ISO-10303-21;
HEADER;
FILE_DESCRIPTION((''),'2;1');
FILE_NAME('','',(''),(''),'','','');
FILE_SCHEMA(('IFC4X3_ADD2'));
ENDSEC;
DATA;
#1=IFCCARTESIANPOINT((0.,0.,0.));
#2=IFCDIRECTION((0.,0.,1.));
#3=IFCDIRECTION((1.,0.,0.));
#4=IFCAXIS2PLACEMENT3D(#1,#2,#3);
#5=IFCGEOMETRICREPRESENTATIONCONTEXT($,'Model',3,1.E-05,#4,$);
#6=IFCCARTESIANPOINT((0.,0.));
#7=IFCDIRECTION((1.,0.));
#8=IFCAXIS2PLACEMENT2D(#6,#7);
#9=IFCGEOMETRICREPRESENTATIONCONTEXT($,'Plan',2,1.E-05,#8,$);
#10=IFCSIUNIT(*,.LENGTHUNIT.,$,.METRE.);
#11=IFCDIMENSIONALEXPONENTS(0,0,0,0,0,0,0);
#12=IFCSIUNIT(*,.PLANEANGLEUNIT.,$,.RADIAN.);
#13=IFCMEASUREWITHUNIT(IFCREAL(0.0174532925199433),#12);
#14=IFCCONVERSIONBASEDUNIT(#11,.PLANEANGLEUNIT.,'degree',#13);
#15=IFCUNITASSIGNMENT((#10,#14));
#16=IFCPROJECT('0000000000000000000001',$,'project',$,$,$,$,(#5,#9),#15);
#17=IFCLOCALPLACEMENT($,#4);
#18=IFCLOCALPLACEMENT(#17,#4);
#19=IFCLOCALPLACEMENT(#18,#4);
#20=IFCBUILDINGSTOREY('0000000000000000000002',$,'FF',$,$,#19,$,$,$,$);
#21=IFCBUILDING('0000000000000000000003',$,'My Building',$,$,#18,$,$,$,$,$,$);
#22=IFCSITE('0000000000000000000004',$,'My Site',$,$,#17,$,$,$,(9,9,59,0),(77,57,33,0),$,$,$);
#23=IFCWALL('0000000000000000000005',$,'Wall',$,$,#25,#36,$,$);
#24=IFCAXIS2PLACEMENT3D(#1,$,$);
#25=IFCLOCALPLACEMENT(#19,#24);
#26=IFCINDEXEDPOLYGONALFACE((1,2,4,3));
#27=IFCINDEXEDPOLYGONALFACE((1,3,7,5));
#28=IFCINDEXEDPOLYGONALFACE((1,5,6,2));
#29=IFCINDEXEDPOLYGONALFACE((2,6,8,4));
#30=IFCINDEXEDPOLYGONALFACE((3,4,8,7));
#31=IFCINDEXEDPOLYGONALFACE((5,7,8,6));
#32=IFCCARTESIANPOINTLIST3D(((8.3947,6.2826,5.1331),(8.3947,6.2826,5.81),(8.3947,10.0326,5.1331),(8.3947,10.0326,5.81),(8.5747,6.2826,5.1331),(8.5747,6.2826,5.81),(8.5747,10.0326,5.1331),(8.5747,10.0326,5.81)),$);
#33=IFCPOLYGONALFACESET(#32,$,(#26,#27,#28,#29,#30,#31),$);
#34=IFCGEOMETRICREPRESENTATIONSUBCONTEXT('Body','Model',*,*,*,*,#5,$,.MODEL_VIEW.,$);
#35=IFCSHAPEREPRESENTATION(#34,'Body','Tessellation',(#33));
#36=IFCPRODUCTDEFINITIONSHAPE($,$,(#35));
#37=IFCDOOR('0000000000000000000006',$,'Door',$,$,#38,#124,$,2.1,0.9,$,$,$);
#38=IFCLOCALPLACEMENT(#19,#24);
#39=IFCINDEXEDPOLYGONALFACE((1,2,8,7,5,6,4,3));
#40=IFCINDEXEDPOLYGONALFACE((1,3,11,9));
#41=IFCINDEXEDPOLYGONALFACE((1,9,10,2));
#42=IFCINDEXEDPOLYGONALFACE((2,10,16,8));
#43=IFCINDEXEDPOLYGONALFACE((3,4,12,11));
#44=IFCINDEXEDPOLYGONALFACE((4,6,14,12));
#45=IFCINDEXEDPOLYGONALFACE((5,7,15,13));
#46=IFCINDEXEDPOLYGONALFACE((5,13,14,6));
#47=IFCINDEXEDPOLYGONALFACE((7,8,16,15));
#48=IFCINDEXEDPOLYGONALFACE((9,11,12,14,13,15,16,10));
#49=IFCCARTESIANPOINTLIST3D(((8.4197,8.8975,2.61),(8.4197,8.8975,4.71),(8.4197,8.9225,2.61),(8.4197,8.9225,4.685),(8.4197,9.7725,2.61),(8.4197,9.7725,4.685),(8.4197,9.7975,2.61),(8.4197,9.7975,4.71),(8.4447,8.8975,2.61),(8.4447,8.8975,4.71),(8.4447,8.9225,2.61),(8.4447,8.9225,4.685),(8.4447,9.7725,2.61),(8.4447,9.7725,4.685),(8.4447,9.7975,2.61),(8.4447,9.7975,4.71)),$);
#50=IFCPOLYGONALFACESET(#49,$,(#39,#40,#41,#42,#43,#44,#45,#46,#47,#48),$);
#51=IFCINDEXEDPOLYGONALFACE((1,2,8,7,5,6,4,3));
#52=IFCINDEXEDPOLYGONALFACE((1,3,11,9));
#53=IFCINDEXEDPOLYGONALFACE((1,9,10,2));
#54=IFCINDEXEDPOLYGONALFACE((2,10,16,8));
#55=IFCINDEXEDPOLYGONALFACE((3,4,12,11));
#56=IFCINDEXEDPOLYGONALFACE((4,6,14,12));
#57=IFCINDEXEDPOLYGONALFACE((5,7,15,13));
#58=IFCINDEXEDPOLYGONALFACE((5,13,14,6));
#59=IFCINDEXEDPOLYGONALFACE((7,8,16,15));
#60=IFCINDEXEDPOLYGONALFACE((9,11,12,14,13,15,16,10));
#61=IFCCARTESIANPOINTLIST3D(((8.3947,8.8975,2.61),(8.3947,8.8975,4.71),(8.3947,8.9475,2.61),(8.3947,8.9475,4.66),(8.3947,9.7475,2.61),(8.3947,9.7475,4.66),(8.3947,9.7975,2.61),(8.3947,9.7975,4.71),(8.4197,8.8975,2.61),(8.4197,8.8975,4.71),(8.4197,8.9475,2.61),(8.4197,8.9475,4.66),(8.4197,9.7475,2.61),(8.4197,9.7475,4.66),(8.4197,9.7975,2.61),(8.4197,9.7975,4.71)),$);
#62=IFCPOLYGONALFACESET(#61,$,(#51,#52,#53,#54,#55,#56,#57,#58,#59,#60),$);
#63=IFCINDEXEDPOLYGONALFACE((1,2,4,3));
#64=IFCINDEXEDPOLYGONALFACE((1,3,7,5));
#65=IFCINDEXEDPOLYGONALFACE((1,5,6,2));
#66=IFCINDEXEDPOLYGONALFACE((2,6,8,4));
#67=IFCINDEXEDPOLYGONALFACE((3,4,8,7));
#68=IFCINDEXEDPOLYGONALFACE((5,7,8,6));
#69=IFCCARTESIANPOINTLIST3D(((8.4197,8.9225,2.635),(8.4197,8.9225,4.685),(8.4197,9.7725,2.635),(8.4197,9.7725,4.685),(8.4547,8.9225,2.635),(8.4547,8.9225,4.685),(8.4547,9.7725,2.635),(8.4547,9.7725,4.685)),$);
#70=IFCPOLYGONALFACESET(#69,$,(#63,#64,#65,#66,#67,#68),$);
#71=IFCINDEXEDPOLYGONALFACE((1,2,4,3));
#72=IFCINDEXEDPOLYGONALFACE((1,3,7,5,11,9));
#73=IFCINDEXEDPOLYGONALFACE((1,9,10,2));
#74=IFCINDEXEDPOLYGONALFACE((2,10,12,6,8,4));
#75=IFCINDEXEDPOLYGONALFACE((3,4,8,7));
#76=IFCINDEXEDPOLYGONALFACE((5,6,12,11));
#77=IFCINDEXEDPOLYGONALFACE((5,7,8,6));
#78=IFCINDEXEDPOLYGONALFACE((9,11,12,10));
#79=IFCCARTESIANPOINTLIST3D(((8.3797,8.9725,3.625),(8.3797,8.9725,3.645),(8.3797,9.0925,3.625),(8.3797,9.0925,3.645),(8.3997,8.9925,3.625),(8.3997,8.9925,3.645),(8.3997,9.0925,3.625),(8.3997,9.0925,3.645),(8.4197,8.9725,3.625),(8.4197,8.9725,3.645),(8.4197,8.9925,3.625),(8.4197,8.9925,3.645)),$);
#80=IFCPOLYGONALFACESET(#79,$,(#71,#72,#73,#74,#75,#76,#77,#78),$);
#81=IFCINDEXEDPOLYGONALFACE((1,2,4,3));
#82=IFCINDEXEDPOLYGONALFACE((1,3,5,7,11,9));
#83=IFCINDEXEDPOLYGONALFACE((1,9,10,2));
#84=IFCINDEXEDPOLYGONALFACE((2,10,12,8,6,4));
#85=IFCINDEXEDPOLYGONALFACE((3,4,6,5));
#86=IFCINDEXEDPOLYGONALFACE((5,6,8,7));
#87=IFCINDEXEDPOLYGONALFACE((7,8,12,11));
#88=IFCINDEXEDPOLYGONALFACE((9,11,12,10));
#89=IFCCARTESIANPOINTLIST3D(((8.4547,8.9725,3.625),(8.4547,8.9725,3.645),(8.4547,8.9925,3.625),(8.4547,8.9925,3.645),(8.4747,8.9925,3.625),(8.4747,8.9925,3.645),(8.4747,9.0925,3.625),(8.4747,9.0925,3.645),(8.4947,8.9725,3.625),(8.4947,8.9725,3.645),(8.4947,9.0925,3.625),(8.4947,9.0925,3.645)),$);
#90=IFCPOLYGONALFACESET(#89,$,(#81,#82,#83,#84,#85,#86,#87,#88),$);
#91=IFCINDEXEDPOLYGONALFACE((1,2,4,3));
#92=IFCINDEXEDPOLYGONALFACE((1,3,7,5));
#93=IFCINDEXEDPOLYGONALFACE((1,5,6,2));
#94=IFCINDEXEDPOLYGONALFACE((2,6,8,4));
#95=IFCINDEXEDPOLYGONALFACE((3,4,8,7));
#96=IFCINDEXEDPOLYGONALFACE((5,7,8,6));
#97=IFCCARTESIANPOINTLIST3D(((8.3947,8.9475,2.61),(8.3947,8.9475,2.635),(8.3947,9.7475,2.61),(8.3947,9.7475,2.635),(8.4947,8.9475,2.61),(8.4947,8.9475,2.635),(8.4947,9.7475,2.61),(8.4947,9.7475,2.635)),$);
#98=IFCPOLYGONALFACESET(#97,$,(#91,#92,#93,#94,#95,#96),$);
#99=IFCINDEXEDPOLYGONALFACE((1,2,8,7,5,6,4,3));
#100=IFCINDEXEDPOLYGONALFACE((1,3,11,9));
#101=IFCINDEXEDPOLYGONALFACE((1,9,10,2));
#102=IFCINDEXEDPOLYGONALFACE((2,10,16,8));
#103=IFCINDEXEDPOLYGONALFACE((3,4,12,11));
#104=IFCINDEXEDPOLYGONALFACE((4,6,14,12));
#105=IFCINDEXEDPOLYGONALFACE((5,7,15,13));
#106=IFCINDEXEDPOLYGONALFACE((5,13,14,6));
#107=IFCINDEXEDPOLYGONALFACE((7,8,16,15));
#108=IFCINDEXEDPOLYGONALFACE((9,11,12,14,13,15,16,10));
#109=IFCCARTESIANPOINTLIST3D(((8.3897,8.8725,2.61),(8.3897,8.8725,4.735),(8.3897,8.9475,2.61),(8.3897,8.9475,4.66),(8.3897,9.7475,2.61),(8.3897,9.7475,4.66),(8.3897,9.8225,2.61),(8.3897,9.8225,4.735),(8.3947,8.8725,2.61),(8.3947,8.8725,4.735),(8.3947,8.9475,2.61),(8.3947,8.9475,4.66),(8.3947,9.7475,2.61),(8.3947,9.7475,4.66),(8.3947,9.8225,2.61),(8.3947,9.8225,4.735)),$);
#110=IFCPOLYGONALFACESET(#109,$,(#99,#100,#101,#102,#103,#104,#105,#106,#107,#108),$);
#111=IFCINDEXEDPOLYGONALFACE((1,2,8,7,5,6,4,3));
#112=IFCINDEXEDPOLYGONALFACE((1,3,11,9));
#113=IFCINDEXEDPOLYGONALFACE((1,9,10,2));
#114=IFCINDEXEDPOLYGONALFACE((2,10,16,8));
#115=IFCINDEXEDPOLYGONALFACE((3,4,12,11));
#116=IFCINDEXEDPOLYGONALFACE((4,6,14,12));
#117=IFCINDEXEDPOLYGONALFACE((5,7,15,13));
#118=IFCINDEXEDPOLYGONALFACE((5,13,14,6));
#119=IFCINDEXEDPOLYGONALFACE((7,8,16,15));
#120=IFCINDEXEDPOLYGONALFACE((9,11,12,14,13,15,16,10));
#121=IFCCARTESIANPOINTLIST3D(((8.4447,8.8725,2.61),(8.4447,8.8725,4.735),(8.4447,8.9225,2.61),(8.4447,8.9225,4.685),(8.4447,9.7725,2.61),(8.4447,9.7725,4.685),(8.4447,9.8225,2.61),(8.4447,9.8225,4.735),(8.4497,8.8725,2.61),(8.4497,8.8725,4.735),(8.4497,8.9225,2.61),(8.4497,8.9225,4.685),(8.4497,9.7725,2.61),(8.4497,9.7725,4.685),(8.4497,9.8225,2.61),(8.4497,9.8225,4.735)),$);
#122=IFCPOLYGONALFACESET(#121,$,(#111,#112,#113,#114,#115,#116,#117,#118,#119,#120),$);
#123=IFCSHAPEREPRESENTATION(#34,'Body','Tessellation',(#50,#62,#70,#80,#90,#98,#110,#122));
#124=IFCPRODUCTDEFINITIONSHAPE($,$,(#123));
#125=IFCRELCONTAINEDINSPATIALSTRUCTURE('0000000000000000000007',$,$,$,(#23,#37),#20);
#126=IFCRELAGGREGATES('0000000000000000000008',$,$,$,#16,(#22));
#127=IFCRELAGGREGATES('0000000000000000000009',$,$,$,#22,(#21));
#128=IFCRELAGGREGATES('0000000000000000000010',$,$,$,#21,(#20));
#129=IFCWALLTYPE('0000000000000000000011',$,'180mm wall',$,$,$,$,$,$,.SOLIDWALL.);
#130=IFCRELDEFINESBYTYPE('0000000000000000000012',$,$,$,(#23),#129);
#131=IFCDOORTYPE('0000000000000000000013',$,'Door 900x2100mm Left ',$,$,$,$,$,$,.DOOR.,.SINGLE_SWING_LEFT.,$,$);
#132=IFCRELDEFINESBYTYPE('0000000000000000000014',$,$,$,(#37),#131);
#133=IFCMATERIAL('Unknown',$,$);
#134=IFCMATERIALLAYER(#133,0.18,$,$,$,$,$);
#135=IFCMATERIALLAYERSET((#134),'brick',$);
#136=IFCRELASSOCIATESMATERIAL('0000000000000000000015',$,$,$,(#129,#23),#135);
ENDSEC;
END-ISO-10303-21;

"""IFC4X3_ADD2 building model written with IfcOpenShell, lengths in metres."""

from ifc_helpers import new_model, entity, si_unit, converted_unit, frame, origin_with_axes, origin_2d_with_axis, place, context, subcontext, project, spatial, line, indexed_curve, outline, extrude, shape, source, transform, mapped, material, layer, layer_set, layer_usage, type_object, type_shapes, element, save


model = new_model("IFC4X3_ADD2")

# Units and contexts
model_context = context("Model", 3, precision=1e-05, world=origin_with_axes())
plan_context = context("Plan", 2, precision=1e-05, world=origin_2d_with_axis())
body_context_1 = subcontext(model_context, "Body", "Model", "MODEL_VIEW")
body_context_2 = subcontext(plan_context, "Body", "Plan", "PLAN_VIEW")
ifc_project = project(units=[si_unit("LENGTHUNIT", "METRE"), converted_unit("PLANEANGLEUNIT", "degree", entity("IfcReal", 0.0174532925199433), si_unit("PLANEANGLEUNIT", "RADIAN"), dimensions=[0, 0, 0, 0, 0, 0, 0])], contexts=[model_context, plan_context])

# Site, building, storey
site_placement = place(None, origin_with_axes())
site = spatial("IfcSite", under=ifc_project, at=site_placement, Name="My Site", RefLatitude=(9, 9, 59, 0), RefLongitude=(77, 57, 33, 0))
building_placement = place(site_placement, origin_with_axes())
building = spatial("IfcBuilding", under=site, at=building_placement, Name="My Building")
storey_placement = place(building_placement, origin_with_axes())
storey = spatial("IfcBuildingStorey", under=building, at=storey_placement, Name="FF")

# Shared definitions
ifc_material = material(Name="Unknown")

# Shared definitions
ifc_layer_1 = layer(ifc_material, 0.18)
ifc_layer_set_1 = layer_set([ifc_layer_1], Name="brick")
wall_type_1 = type_object("IfcWallType", Name="180mm wall", PredefinedType="SOLIDWALL", material=ifc_layer_set_1)

# Shared definitions
wall_1_placement = place(storey_placement, frame((8.5747, 8.3164, 2.61), z_axis=(0.0, 0.0, 1.0), x_axis=(0.0, 1.0, 0.0)))

# Wall
ifc_layer_usage_1 = layer_usage(ifc_layer_set_1, "AXIS2", "POSITIVE", 0.0)
wall_2_placement = place(storey_placement, frame((8.3947, 10.0326, 5.1331), z_axis=(0.0, 0.0, 1.0), x_axis=(-0.000001, -1.0, 0.0)))
element("IfcWall", 1, at=wall_2_placement, inside=storey, type_object=wall_type_1, material=ifc_layer_usage_1, Name="Wall", context=body_context_1, shape_type="SweptSolid", body=[
    extrude(outline(indexed_curve([(0.0, 0.0), (0.0, 0.18), (3.75, 0.18), (3.75, 0.0)], segments=[line(1, 2, 3, 4, 1)])), origin_with_axes(), (0.0, 0.0, 1.0), 0.6769),
])

# Door
door_type_1 = type_object("IfcDoorType", Name="Door 900x2100mm Left ", OperationType="SINGLE_SWING_LEFT", PredefinedType="DOOR")
shared_shape_1 = source(origin_with_axes(), body_context_1, "Body", "SweptSolid", [
    extrude(outline(indexed_curve([(0.0, 0.0), (0.0, 2.1), (0.9, 2.1), (0.9, 0.0), (0.875, 0.0), (0.875, 2.075), (0.025, 2.075), (0.025, 0.0)], segments=[line(1, 2, 3, 4, 5, 6, 7, 8, 1)])), frame((0.0, 0.025, 0.0), z_axis=(0.0, -1.0, 0.0), x_axis=(1.0, 0.0, 0.0)), (0.0, 0.0, -1.0), 0.025),
    extrude(outline(indexed_curve([(0.0, 0.0), (0.0, 2.1), (0.9, 2.1), (0.9, 0.0), (0.85, 0.0), (0.85, 2.05), (0.05, 2.05), (0.05, 0.0)], segments=[line(1, 2, 3, 4, 5, 6, 7, 8, 1)])), frame((0.0, 0.0, 0.0), z_axis=(0.0, -1.0, 0.0), x_axis=(1.0, 0.0, 0.0)), (0.0, 0.0, -1.0), 0.025),
    extrude(outline(indexed_curve([(0.0, 0.0), (0.85, 0.0), (0.85, 0.035), (0.0, 0.035)], segments=[line(1, 2, 3, 4, 1)])), frame((0.025, 0.025, 0.025), z_axis=(0.0, 0.0, 1.0), x_axis=(1.0, 0.0, 0.0)), (0.0, 0.0, 1.0), 2.05),
    extrude(outline(indexed_curve([(0.0, 0.0), (0.0, -0.04), (-0.12, -0.04), (-0.12, -0.02), (-0.02, -0.02), (-0.02, 0.0)], segments=[line(1, 2, 3, 4, 5, 6, 1)])), frame((0.825, 0.025, 1.015), z_axis=(0.0, 0.0, 1.0), x_axis=(1.0, 0.0, 0.0)), (0.0, 0.0, 1.0), 0.02),
    extrude(outline(indexed_curve([(0.0, 0.0), (0.0, 0.04), (-0.12, 0.04), (-0.12, 0.02), (-0.02, 0.02), (-0.02, 0.0)], segments=[line(1, 2, 3, 4, 5, 6, 1)])), frame((0.825, 0.06, 1.015), z_axis=(0.0, 0.0, 1.0), x_axis=(1.0, 0.0, 0.0)), (0.0, 0.0, 1.0), 0.02),
    extrude(outline(indexed_curve([(0.0, 0.0), (0.8, 0.0), (0.8, 0.1), (0.0, 0.1)], segments=[line(1, 2, 3, 4, 1)])), frame((0.05, 0.0, 0.0), z_axis=(0.0, 0.0, 1.0), x_axis=(1.0, 0.0, 0.0)), (0.0, 0.0, 1.0), 0.025),
    extrude(outline(indexed_curve([(0.0, 0.0), (0.0, 2.125), (0.95, 2.125), (0.95, 0.0), (0.875, 0.0), (0.875, 2.05), (0.075, 2.05), (0.075, 0.0)], segments=[line(1, 2, 3, 4, 5, 6, 7, 8, 1)])), frame((-0.025, -0.005, 0.0), z_axis=(0.0, -1.0, 0.0), x_axis=(1.0, 0.0, 0.0)), (0.0, 0.0, -1.0), 0.005),
    extrude(outline(indexed_curve([(0.0, 0.0), (0.0, 2.125), (0.95, 2.125), (0.95, 0.0), (0.9, 0.0), (0.9, 2.075), (0.05, 2.075), (0.05, 0.0)], segments=[line(1, 2, 3, 4, 5, 6, 7, 8, 1)])), frame((-0.025, 0.05, 0.0), z_axis=(0.0, -1.0, 0.0), x_axis=(1.0, 0.0, 0.0)), (0.0, 0.0, -1.0), 0.005),
])
shared_shape_2 = source(origin_with_axes(), body_context_2, "Body", "Curve2D", [
    entity("IfcIndexedPolyCurve", entity("IfcCartesianPointList2D", [[0.0, 0.0], [0.0, 0.05], [0.025, 0.05], [0.025, 0.025], [0.05, 0.025], [0.05, 0.0]]), [entity("IfcLineIndex", [1, 2, 3, 4, 5, 6, 1])]),
    entity("IfcIndexedPolyCurve", entity("IfcCartesianPointList2D", [[0.9, 0.0], [0.9, 0.05], [0.875, 0.05], [0.875, 0.025], [0.85, 0.025], [0.85, 0.0]]), [entity("IfcLineIndex", [1, 2, 3, 4, 5, 6, 1])]),
    entity("IfcTrimmedCurve", entity("IfcEllipse", entity("IfcAxis2Placement2D", entity("IfcCartesianPoint", [0.06, 0.05]), entity("IfcDirection", [1.0, 0.0])), 0.815, 0.85), [entity("IfcCartesianPoint", [0.875, 0.05])], [entity("IfcCartesianPoint", [0.06, 0.9])], True, "CARTESIAN"),
    entity("IfcIndexedPolyCurve", entity("IfcCartesianPointList2D", [[0.025, 0.05], [0.06, 0.05], [0.06, 0.9], [0.025, 0.9]]), [entity("IfcLineIndex", [1, 2, 3, 4, 1])]),
])
type_shapes(door_type_1, [shared_shape_1, shared_shape_2])
placement = place(wall_1_placement, frame((2.356, 0.18, 0.0), z_axis=(0.0, 0.0, 1.0), x_axis=(-1.0, 0.0, 0.0)))
door_1_placement = place(placement, frame((0.875, 0.0, 0.0), z_axis=(0.0, 0.0, 1.0), x_axis=(1.0, 0.0, 0.0)))
element("IfcDoor", 2, at=door_1_placement, inside=storey, type_object=door_type_1, Name="Door", OverallHeight=2.1, OverallWidth=0.9, shapes=[
    shape(body_context_1, "Body", "MappedRepresentation", [mapped(shared_shape_1, transform((0.0, 0.0, 0.0), x_axis=(1.0, 0.0, 0.0), y_axis=(0.0, 1.0, 0.0), z_axis=(0.0, 0.0, 1.0), scale=1.0))]),
    shape(body_context_2, "Body", "MappedRepresentation", [mapped(shared_shape_2, transform((0.0, 0.0, 0.0), x_axis=(1.0, 0.0, 0.0), y_axis=(0.0, 1.0, 0.0), z_axis=(0.0, 0.0, 1.0), scale=1.0))]),
])

save(model, "model.ifc")
